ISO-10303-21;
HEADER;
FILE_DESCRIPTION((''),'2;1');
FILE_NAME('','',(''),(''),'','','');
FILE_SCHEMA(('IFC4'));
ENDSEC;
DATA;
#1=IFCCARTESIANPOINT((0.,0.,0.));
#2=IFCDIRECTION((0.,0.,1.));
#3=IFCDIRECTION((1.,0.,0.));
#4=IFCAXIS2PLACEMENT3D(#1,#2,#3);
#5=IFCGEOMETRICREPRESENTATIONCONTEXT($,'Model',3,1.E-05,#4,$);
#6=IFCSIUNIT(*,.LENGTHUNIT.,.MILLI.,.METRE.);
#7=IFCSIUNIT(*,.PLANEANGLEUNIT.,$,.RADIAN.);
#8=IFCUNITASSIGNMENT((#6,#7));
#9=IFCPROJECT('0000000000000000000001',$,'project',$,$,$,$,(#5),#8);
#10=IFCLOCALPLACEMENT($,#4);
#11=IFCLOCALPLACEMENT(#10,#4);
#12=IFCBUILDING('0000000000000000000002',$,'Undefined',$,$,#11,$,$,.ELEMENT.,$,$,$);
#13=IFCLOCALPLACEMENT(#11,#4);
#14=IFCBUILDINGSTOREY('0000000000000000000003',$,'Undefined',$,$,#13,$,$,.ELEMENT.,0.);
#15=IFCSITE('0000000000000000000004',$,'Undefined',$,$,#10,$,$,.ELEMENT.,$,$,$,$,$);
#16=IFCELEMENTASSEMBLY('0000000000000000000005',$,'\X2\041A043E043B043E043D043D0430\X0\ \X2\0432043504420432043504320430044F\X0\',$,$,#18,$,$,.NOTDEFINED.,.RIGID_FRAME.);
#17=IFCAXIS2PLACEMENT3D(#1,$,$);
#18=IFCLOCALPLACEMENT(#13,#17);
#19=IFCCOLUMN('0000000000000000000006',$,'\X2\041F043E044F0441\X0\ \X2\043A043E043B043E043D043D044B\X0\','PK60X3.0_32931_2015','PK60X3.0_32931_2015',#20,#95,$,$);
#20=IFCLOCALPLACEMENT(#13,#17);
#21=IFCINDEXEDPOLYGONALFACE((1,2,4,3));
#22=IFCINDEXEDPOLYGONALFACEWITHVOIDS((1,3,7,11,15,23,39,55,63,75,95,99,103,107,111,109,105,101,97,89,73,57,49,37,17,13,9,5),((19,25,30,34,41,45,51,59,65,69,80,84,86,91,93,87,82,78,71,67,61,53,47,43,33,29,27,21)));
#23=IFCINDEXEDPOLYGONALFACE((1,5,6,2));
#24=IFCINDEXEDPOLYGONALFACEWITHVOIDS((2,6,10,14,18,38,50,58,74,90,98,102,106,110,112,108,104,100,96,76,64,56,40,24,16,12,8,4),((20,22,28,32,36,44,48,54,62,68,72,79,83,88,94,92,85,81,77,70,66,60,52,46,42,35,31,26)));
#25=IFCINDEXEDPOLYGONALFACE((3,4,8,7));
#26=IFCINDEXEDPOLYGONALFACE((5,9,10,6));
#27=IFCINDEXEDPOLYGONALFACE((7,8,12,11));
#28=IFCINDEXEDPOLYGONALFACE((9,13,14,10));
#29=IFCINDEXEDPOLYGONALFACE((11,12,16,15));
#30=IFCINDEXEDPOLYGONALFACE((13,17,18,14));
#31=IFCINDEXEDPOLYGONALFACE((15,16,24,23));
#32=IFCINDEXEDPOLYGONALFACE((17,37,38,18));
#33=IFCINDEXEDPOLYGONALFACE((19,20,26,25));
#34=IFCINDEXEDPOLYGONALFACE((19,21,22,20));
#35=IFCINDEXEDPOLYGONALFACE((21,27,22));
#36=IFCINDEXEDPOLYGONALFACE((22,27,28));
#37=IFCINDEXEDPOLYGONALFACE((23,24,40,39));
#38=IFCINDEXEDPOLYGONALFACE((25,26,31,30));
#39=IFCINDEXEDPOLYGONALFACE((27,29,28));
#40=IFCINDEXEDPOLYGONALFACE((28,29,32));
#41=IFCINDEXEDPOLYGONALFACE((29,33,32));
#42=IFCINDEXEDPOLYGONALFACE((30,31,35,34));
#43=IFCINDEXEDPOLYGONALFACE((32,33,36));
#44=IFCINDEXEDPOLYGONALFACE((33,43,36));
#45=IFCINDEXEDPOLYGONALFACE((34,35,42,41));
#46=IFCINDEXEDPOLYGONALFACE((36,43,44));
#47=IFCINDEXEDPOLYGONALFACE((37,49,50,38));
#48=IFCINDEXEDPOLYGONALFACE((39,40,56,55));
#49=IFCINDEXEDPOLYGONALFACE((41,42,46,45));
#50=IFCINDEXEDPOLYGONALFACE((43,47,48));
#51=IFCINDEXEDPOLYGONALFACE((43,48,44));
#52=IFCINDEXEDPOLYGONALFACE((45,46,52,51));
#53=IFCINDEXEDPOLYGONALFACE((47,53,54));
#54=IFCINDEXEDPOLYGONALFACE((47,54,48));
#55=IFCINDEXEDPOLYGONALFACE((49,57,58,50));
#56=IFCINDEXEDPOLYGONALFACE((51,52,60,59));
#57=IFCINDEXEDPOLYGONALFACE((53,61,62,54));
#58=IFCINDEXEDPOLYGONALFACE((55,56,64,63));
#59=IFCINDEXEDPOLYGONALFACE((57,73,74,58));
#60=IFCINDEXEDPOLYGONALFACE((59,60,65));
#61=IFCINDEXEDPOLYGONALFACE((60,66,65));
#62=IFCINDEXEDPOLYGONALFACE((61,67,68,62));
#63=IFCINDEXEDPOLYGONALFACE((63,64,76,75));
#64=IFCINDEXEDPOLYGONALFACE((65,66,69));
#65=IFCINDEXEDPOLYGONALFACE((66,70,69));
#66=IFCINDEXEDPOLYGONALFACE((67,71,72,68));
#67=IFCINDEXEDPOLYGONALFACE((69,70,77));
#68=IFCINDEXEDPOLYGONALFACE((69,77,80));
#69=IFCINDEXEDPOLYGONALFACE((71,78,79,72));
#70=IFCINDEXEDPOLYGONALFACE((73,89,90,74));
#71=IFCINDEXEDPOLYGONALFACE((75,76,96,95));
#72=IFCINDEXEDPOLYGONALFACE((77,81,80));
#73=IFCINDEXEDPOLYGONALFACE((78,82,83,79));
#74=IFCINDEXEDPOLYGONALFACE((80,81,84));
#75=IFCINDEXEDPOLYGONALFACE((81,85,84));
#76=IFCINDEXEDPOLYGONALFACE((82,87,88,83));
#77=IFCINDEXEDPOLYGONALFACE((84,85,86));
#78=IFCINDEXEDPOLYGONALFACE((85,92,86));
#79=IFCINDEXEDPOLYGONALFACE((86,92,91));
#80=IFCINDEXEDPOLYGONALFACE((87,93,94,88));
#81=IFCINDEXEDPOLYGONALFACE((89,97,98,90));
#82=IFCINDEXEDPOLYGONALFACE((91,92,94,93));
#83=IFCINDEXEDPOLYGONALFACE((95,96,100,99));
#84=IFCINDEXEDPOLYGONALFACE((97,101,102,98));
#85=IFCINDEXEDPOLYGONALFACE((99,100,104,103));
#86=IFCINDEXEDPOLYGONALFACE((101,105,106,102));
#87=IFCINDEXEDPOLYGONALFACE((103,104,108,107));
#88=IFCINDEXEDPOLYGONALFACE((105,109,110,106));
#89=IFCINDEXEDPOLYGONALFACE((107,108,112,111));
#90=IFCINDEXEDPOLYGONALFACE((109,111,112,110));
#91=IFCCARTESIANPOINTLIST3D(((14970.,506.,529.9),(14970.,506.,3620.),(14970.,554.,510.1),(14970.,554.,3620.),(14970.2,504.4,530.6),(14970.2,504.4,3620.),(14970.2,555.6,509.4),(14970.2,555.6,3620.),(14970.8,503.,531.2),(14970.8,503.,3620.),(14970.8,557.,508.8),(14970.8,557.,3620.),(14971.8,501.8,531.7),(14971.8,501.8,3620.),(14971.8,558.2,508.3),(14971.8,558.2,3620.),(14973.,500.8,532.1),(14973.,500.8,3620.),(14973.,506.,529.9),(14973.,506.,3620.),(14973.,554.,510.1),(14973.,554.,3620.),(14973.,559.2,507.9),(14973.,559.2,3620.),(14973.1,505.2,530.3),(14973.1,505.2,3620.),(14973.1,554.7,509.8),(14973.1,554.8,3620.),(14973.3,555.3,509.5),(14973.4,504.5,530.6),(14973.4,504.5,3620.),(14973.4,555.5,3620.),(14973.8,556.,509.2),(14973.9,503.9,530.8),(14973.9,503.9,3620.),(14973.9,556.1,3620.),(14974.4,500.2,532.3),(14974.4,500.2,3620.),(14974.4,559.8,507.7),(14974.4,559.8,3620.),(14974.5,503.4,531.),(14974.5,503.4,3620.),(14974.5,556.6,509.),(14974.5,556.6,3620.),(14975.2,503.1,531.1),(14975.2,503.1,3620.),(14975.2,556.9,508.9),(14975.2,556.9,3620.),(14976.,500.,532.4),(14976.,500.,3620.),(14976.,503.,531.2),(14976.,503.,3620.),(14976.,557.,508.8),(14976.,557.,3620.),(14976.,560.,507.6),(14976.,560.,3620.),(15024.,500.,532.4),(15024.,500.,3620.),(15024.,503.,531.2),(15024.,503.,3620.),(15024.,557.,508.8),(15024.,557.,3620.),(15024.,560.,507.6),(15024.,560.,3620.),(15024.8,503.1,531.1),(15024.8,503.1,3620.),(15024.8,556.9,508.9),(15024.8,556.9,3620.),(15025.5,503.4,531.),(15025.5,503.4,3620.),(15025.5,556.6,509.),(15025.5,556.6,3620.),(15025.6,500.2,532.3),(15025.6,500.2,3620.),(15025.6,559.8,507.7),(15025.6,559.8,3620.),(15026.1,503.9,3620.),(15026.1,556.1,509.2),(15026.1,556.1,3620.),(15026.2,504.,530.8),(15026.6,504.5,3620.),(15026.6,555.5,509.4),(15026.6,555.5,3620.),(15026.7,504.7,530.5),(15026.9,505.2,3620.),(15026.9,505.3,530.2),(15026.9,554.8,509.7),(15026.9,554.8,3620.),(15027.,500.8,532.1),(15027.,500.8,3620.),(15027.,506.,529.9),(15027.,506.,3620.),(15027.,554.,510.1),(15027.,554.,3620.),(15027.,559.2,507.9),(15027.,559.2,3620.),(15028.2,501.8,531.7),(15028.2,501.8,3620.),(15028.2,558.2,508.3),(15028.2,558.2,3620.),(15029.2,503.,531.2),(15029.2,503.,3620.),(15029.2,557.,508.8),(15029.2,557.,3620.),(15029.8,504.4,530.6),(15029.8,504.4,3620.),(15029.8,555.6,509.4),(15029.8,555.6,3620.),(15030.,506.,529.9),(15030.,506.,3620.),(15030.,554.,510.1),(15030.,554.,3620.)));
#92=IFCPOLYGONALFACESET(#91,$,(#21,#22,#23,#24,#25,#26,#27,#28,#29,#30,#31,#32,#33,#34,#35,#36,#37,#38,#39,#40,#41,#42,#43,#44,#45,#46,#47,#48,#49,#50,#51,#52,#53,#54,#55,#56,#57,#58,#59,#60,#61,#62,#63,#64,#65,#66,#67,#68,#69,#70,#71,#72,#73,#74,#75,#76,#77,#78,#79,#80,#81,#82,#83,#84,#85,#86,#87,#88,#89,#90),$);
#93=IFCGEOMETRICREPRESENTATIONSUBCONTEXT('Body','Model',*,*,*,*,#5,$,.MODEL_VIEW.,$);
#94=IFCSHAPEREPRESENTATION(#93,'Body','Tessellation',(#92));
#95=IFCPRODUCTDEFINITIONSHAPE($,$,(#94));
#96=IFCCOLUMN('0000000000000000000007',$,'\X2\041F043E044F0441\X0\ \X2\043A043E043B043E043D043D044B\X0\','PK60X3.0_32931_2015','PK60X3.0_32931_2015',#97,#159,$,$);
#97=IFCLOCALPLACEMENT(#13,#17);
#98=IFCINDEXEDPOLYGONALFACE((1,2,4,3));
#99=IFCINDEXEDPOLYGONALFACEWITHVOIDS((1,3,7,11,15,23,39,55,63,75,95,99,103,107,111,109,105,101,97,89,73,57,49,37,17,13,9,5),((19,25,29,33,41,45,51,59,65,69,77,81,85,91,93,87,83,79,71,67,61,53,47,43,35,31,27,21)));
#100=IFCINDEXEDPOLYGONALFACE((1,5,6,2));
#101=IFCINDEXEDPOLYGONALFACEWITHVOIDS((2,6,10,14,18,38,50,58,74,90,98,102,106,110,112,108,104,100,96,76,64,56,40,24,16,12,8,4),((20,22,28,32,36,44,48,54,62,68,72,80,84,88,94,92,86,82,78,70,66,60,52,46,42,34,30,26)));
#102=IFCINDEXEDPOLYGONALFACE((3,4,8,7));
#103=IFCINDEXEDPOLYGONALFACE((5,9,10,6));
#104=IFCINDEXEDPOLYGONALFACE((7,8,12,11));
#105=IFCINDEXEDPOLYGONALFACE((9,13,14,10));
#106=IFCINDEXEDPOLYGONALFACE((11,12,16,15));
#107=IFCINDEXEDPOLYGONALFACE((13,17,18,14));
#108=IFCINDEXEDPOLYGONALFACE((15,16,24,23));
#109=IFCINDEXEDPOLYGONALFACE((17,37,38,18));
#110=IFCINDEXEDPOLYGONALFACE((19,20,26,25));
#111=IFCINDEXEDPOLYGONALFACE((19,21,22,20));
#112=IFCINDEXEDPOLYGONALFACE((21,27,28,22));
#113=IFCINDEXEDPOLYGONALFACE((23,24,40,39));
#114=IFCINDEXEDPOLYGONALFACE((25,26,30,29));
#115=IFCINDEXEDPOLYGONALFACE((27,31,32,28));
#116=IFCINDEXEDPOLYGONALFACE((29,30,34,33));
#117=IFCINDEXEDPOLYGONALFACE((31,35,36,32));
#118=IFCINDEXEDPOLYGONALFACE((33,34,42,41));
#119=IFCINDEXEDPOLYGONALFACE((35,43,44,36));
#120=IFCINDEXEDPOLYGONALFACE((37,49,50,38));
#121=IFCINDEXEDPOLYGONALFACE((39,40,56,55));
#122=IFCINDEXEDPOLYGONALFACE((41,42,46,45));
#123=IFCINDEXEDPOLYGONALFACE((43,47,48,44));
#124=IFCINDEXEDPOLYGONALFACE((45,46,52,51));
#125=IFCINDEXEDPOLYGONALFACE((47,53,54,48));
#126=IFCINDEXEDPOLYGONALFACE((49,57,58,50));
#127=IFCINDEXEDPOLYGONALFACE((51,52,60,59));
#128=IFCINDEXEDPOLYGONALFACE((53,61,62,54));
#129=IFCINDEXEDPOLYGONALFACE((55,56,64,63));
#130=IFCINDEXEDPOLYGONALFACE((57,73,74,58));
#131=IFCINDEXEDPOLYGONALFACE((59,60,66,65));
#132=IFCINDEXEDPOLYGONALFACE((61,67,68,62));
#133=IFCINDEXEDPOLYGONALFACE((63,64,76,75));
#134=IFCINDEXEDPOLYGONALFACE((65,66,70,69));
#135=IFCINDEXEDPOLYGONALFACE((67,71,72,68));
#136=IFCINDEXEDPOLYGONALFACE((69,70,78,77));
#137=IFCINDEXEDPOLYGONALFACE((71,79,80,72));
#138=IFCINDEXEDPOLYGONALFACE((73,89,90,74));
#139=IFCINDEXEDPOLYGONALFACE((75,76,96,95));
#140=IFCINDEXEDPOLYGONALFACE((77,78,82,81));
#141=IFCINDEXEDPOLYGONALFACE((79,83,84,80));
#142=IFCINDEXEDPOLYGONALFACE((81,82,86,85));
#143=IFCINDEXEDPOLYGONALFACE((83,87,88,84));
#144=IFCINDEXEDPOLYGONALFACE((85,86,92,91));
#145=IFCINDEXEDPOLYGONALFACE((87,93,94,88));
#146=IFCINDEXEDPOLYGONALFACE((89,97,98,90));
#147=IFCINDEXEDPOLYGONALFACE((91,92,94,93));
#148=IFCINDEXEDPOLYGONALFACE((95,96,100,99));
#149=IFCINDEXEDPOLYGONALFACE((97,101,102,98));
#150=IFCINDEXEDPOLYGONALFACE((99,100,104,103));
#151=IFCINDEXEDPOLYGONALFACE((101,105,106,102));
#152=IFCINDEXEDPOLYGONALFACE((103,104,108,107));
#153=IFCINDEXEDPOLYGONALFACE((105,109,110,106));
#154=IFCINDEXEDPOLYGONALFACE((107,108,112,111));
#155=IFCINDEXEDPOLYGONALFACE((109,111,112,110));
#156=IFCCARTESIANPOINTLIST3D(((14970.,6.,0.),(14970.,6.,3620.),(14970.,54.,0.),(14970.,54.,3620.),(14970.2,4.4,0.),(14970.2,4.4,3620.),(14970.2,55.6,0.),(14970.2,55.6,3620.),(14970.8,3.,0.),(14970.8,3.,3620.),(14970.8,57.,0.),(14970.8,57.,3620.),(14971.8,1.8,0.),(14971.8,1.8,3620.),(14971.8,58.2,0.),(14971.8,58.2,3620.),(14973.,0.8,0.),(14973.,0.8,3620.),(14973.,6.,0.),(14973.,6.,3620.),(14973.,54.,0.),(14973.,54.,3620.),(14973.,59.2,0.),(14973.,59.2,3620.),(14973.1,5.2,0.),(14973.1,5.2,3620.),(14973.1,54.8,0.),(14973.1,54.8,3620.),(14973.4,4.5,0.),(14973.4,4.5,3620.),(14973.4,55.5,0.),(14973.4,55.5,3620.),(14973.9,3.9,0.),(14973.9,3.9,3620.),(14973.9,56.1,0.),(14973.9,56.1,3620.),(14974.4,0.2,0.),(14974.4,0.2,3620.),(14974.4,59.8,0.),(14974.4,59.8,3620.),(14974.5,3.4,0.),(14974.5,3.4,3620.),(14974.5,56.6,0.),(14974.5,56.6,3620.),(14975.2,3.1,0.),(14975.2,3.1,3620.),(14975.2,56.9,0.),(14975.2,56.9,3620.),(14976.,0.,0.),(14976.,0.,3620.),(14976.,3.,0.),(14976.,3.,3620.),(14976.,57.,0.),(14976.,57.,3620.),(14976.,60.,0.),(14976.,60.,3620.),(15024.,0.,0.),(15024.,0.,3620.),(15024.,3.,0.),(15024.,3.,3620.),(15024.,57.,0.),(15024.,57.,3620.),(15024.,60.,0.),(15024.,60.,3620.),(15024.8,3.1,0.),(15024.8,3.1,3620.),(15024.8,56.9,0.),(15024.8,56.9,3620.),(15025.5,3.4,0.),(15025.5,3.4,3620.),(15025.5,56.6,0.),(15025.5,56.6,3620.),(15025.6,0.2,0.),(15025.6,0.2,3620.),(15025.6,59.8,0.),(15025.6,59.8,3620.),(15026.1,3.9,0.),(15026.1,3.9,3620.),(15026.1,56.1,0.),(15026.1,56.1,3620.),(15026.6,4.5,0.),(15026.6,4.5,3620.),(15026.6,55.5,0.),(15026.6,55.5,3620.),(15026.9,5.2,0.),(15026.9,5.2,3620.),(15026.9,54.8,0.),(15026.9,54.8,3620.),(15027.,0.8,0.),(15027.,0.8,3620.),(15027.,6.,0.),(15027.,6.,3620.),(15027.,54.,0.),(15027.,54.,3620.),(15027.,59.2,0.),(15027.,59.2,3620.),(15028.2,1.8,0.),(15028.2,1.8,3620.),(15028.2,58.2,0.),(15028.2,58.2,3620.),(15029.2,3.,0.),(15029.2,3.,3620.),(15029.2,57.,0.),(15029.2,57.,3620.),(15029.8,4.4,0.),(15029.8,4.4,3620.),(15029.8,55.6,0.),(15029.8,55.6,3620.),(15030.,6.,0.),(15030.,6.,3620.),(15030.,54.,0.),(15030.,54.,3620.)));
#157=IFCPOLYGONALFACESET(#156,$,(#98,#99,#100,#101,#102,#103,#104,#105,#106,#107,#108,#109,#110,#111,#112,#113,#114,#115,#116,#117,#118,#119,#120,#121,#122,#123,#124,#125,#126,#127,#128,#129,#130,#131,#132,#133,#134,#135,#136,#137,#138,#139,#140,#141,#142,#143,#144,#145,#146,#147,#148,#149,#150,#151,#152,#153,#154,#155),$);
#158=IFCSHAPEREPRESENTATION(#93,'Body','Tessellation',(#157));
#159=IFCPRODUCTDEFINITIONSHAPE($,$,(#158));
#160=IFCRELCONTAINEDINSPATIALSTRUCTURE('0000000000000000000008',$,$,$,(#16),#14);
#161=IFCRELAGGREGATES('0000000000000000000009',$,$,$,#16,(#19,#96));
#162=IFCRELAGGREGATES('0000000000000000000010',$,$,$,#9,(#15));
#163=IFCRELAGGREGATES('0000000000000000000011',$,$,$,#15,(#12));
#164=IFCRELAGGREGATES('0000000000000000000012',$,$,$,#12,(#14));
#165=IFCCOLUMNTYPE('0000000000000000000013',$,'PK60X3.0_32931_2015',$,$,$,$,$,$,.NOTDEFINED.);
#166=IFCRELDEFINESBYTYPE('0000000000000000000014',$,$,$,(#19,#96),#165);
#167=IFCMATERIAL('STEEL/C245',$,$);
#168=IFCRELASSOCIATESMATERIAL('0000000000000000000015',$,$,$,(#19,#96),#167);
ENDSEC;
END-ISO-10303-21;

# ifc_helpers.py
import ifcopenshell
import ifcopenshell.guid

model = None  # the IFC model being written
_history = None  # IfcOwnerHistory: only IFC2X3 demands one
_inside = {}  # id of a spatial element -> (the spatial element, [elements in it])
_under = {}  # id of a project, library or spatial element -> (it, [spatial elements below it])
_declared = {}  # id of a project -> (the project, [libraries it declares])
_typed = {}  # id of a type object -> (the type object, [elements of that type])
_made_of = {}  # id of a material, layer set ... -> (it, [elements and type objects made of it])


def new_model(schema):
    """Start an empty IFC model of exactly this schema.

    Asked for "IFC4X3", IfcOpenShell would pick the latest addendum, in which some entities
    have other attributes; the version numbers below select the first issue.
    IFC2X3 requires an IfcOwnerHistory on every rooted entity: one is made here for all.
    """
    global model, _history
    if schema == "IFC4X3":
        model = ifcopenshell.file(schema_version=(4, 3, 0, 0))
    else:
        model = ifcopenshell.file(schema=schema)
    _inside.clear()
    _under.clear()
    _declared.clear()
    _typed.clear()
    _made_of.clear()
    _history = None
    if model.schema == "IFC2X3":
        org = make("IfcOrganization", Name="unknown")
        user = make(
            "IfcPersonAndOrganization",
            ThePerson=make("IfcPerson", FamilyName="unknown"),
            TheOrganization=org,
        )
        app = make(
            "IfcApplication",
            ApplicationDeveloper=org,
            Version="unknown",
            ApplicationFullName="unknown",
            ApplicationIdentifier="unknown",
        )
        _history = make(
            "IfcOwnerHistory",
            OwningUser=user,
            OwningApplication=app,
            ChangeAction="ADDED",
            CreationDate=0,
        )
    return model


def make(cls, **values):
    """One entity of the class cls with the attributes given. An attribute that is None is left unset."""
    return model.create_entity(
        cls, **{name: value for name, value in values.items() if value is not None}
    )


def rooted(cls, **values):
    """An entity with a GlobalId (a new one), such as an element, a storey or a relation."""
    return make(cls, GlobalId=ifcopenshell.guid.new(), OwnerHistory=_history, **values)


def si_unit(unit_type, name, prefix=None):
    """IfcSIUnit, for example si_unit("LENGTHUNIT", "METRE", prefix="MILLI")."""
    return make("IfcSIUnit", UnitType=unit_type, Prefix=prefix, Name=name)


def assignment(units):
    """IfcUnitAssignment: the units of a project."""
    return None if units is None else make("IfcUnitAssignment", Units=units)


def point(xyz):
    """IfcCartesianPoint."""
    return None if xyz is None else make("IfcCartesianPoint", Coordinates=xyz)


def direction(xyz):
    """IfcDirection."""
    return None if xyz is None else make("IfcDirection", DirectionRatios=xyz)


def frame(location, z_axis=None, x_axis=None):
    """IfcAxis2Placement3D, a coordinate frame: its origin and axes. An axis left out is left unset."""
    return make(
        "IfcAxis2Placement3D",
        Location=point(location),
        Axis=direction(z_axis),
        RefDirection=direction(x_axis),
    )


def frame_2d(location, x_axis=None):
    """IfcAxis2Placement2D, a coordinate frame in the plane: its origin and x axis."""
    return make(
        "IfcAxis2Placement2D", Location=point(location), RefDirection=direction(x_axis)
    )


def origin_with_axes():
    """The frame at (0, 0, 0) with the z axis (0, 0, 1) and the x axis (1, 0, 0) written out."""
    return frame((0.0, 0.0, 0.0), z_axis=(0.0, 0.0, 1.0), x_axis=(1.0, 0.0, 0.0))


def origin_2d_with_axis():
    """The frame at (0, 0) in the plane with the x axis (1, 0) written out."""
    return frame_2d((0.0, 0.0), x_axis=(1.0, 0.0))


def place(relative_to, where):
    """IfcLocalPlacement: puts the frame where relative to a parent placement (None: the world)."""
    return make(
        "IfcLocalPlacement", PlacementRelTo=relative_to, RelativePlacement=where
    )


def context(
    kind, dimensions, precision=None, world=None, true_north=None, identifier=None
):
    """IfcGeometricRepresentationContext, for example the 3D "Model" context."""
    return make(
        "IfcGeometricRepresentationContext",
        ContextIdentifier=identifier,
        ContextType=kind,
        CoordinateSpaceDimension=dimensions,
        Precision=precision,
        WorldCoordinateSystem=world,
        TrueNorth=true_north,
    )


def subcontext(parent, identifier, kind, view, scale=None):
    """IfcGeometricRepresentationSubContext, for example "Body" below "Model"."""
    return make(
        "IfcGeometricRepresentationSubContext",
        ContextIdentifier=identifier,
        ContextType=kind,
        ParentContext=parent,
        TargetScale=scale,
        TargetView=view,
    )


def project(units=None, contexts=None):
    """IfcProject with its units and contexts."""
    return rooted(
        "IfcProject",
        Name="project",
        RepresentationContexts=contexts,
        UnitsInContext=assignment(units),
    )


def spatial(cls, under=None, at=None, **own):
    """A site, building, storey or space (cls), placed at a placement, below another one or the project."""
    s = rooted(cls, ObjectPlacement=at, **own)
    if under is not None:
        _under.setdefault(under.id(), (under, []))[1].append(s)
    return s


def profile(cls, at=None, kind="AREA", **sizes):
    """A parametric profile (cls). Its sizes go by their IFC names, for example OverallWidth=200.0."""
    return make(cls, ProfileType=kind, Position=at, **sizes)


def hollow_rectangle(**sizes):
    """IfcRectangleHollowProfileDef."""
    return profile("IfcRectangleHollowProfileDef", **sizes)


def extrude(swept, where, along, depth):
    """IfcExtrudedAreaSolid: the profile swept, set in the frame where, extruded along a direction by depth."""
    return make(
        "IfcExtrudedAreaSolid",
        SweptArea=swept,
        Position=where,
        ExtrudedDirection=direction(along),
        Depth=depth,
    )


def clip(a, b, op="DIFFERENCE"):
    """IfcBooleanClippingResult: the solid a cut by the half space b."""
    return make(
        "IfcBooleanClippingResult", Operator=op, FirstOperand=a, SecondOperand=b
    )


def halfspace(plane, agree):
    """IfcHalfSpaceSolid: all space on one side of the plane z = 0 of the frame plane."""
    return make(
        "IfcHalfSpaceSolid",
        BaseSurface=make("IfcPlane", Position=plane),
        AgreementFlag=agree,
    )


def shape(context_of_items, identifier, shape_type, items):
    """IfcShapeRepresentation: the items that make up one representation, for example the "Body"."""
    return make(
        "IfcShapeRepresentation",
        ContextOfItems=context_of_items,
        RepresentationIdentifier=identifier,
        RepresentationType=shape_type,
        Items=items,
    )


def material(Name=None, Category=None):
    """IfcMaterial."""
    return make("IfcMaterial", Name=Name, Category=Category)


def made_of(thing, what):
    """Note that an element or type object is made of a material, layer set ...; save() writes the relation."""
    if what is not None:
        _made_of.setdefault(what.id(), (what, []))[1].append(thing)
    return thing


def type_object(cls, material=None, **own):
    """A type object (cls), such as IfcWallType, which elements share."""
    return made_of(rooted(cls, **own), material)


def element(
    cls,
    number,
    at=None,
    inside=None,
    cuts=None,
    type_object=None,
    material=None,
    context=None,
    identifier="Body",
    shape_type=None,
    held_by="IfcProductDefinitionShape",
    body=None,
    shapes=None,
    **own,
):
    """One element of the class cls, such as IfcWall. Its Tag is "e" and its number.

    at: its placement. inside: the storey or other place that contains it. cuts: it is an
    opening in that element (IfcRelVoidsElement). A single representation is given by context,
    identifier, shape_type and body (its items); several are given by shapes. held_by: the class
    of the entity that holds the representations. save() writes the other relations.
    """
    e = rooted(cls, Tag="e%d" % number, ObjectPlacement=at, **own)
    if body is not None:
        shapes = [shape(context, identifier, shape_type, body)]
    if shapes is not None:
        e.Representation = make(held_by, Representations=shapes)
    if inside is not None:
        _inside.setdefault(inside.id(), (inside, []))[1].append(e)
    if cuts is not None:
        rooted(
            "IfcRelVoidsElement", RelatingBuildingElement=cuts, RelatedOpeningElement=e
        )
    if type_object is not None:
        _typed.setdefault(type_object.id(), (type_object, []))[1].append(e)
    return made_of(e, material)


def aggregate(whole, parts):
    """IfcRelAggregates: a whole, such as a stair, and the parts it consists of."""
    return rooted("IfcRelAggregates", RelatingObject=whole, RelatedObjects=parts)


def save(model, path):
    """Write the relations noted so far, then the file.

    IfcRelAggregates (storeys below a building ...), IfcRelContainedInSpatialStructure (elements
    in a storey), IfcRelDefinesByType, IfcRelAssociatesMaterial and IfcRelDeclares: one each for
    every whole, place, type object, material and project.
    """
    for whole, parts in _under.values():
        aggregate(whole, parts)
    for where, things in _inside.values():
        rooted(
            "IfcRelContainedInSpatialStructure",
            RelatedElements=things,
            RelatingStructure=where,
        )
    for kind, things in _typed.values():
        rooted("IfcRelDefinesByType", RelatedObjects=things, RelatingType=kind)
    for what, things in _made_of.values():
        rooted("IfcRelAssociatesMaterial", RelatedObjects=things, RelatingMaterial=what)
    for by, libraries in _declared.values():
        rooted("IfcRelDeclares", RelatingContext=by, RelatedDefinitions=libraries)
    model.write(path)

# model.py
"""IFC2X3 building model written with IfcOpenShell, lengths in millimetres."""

from ifc_helpers import new_model, si_unit, frame, origin_with_axes, origin_2d_with_axis, place, context, subcontext, project, spatial, hollow_rectangle, extrude, clip, halfspace, material, type_object, element, aggregate, save


model = new_model("IFC2X3")

# Units and contexts
model_context = context("Model", 3, precision=1e-05, world=origin_with_axes())
body_context = subcontext(model_context, "Body", "Model", "MODEL_VIEW")
ifc_project = project(units=[si_unit("LENGTHUNIT", "METRE", prefix="MILLI"), si_unit("PLANEANGLEUNIT", "RADIAN")], contexts=[model_context])

# Site, building, storey
site_placement = place(None, origin_with_axes())
site = spatial("IfcSite", under=ifc_project, at=site_placement, Name="Undefined", CompositionType="ELEMENT")
building_placement = place(site_placement, origin_with_axes())
building = spatial("IfcBuilding", under=site, at=building_placement, Name="Undefined", CompositionType="ELEMENT")
storey_placement = place(building_placement, origin_with_axes())
storey = spatial("IfcBuildingStorey", under=building, at=storey_placement, Name="Undefined", CompositionType="ELEMENT", Elevation=0.0)

# Element assembly, columns
assembly_1_placement = place(storey_placement, origin_with_axes())
assembly_1 = element("IfcElementAssembly", 1, at=assembly_1_placement, inside=storey, Name="Колонна ветвевая", AssemblyPlace="NOTDEFINED", PredefinedType="RIGID_FRAME")
ifc_material_1 = material(Name="STEEL/C245")
column_type = type_object("IfcColumnType", Name="PK60X3.0_32931_2015", PredefinedType="NOTDEFINED")
column_1_placement = place(assembly_1_placement, frame((15000.0, 530.0, 0.0), z_axis=(0.0, 0.0, 1.0), x_axis=(-1.0, 0.0, 0.0)))
column_1 = element("IfcColumn", 2, at=column_1_placement, type_object=column_type, material=ifc_material_1, Name="Пояс колонны", Description="PK60X3.0_32931_2015", ObjectType="PK60X3.0_32931_2015", context=body_context, shape_type="Clipping", body=[
    clip(extrude(hollow_rectangle(XDim=60.0, YDim=60.0, WallThickness=3.0, InnerFilletRadius=3.0, OuterFilletRadius=6.0, at=origin_2d_with_axis()), frame((0.0, 0.0, 3620.0), z_axis=(0.0, 0.0, -1.0), x_axis=(0.0, 1.0, 0.0)), (0.0, 0.0, 1.0), 3112.6), halfspace(frame((0.0, 30.0, 532.4), z_axis=(0.0, -0.382683, 0.92388), x_axis=(1.0, 0.0, 0.0)), True)),
])
column_2_placement = place(assembly_1_placement, frame((15000.0, 30.0, 0.0), z_axis=(0.0, 0.0, 1.0), x_axis=(-1.0, 0.0, 0.0)))
column_2 = element("IfcColumn", 3, at=column_2_placement, type_object=column_type, material=ifc_material_1, Name="Пояс колонны", Description="PK60X3.0_32931_2015", ObjectType="PK60X3.0_32931_2015", context=body_context, shape_type="SweptSolid", body=[
    extrude(hollow_rectangle(XDim=60.0, YDim=60.0, WallThickness=3.0, InnerFilletRadius=3.0, OuterFilletRadius=6.0, at=origin_2d_with_axis()), frame((0.0, 0.0, 3620.0), z_axis=(0.0, 0.0, -1.0), x_axis=(0.0, 1.0, 0.0)), (0.0, 0.0, 1.0), 3620.0),
])

aggregate(assembly_1, [column_1, column_2])

save(model, "model.ifc")
